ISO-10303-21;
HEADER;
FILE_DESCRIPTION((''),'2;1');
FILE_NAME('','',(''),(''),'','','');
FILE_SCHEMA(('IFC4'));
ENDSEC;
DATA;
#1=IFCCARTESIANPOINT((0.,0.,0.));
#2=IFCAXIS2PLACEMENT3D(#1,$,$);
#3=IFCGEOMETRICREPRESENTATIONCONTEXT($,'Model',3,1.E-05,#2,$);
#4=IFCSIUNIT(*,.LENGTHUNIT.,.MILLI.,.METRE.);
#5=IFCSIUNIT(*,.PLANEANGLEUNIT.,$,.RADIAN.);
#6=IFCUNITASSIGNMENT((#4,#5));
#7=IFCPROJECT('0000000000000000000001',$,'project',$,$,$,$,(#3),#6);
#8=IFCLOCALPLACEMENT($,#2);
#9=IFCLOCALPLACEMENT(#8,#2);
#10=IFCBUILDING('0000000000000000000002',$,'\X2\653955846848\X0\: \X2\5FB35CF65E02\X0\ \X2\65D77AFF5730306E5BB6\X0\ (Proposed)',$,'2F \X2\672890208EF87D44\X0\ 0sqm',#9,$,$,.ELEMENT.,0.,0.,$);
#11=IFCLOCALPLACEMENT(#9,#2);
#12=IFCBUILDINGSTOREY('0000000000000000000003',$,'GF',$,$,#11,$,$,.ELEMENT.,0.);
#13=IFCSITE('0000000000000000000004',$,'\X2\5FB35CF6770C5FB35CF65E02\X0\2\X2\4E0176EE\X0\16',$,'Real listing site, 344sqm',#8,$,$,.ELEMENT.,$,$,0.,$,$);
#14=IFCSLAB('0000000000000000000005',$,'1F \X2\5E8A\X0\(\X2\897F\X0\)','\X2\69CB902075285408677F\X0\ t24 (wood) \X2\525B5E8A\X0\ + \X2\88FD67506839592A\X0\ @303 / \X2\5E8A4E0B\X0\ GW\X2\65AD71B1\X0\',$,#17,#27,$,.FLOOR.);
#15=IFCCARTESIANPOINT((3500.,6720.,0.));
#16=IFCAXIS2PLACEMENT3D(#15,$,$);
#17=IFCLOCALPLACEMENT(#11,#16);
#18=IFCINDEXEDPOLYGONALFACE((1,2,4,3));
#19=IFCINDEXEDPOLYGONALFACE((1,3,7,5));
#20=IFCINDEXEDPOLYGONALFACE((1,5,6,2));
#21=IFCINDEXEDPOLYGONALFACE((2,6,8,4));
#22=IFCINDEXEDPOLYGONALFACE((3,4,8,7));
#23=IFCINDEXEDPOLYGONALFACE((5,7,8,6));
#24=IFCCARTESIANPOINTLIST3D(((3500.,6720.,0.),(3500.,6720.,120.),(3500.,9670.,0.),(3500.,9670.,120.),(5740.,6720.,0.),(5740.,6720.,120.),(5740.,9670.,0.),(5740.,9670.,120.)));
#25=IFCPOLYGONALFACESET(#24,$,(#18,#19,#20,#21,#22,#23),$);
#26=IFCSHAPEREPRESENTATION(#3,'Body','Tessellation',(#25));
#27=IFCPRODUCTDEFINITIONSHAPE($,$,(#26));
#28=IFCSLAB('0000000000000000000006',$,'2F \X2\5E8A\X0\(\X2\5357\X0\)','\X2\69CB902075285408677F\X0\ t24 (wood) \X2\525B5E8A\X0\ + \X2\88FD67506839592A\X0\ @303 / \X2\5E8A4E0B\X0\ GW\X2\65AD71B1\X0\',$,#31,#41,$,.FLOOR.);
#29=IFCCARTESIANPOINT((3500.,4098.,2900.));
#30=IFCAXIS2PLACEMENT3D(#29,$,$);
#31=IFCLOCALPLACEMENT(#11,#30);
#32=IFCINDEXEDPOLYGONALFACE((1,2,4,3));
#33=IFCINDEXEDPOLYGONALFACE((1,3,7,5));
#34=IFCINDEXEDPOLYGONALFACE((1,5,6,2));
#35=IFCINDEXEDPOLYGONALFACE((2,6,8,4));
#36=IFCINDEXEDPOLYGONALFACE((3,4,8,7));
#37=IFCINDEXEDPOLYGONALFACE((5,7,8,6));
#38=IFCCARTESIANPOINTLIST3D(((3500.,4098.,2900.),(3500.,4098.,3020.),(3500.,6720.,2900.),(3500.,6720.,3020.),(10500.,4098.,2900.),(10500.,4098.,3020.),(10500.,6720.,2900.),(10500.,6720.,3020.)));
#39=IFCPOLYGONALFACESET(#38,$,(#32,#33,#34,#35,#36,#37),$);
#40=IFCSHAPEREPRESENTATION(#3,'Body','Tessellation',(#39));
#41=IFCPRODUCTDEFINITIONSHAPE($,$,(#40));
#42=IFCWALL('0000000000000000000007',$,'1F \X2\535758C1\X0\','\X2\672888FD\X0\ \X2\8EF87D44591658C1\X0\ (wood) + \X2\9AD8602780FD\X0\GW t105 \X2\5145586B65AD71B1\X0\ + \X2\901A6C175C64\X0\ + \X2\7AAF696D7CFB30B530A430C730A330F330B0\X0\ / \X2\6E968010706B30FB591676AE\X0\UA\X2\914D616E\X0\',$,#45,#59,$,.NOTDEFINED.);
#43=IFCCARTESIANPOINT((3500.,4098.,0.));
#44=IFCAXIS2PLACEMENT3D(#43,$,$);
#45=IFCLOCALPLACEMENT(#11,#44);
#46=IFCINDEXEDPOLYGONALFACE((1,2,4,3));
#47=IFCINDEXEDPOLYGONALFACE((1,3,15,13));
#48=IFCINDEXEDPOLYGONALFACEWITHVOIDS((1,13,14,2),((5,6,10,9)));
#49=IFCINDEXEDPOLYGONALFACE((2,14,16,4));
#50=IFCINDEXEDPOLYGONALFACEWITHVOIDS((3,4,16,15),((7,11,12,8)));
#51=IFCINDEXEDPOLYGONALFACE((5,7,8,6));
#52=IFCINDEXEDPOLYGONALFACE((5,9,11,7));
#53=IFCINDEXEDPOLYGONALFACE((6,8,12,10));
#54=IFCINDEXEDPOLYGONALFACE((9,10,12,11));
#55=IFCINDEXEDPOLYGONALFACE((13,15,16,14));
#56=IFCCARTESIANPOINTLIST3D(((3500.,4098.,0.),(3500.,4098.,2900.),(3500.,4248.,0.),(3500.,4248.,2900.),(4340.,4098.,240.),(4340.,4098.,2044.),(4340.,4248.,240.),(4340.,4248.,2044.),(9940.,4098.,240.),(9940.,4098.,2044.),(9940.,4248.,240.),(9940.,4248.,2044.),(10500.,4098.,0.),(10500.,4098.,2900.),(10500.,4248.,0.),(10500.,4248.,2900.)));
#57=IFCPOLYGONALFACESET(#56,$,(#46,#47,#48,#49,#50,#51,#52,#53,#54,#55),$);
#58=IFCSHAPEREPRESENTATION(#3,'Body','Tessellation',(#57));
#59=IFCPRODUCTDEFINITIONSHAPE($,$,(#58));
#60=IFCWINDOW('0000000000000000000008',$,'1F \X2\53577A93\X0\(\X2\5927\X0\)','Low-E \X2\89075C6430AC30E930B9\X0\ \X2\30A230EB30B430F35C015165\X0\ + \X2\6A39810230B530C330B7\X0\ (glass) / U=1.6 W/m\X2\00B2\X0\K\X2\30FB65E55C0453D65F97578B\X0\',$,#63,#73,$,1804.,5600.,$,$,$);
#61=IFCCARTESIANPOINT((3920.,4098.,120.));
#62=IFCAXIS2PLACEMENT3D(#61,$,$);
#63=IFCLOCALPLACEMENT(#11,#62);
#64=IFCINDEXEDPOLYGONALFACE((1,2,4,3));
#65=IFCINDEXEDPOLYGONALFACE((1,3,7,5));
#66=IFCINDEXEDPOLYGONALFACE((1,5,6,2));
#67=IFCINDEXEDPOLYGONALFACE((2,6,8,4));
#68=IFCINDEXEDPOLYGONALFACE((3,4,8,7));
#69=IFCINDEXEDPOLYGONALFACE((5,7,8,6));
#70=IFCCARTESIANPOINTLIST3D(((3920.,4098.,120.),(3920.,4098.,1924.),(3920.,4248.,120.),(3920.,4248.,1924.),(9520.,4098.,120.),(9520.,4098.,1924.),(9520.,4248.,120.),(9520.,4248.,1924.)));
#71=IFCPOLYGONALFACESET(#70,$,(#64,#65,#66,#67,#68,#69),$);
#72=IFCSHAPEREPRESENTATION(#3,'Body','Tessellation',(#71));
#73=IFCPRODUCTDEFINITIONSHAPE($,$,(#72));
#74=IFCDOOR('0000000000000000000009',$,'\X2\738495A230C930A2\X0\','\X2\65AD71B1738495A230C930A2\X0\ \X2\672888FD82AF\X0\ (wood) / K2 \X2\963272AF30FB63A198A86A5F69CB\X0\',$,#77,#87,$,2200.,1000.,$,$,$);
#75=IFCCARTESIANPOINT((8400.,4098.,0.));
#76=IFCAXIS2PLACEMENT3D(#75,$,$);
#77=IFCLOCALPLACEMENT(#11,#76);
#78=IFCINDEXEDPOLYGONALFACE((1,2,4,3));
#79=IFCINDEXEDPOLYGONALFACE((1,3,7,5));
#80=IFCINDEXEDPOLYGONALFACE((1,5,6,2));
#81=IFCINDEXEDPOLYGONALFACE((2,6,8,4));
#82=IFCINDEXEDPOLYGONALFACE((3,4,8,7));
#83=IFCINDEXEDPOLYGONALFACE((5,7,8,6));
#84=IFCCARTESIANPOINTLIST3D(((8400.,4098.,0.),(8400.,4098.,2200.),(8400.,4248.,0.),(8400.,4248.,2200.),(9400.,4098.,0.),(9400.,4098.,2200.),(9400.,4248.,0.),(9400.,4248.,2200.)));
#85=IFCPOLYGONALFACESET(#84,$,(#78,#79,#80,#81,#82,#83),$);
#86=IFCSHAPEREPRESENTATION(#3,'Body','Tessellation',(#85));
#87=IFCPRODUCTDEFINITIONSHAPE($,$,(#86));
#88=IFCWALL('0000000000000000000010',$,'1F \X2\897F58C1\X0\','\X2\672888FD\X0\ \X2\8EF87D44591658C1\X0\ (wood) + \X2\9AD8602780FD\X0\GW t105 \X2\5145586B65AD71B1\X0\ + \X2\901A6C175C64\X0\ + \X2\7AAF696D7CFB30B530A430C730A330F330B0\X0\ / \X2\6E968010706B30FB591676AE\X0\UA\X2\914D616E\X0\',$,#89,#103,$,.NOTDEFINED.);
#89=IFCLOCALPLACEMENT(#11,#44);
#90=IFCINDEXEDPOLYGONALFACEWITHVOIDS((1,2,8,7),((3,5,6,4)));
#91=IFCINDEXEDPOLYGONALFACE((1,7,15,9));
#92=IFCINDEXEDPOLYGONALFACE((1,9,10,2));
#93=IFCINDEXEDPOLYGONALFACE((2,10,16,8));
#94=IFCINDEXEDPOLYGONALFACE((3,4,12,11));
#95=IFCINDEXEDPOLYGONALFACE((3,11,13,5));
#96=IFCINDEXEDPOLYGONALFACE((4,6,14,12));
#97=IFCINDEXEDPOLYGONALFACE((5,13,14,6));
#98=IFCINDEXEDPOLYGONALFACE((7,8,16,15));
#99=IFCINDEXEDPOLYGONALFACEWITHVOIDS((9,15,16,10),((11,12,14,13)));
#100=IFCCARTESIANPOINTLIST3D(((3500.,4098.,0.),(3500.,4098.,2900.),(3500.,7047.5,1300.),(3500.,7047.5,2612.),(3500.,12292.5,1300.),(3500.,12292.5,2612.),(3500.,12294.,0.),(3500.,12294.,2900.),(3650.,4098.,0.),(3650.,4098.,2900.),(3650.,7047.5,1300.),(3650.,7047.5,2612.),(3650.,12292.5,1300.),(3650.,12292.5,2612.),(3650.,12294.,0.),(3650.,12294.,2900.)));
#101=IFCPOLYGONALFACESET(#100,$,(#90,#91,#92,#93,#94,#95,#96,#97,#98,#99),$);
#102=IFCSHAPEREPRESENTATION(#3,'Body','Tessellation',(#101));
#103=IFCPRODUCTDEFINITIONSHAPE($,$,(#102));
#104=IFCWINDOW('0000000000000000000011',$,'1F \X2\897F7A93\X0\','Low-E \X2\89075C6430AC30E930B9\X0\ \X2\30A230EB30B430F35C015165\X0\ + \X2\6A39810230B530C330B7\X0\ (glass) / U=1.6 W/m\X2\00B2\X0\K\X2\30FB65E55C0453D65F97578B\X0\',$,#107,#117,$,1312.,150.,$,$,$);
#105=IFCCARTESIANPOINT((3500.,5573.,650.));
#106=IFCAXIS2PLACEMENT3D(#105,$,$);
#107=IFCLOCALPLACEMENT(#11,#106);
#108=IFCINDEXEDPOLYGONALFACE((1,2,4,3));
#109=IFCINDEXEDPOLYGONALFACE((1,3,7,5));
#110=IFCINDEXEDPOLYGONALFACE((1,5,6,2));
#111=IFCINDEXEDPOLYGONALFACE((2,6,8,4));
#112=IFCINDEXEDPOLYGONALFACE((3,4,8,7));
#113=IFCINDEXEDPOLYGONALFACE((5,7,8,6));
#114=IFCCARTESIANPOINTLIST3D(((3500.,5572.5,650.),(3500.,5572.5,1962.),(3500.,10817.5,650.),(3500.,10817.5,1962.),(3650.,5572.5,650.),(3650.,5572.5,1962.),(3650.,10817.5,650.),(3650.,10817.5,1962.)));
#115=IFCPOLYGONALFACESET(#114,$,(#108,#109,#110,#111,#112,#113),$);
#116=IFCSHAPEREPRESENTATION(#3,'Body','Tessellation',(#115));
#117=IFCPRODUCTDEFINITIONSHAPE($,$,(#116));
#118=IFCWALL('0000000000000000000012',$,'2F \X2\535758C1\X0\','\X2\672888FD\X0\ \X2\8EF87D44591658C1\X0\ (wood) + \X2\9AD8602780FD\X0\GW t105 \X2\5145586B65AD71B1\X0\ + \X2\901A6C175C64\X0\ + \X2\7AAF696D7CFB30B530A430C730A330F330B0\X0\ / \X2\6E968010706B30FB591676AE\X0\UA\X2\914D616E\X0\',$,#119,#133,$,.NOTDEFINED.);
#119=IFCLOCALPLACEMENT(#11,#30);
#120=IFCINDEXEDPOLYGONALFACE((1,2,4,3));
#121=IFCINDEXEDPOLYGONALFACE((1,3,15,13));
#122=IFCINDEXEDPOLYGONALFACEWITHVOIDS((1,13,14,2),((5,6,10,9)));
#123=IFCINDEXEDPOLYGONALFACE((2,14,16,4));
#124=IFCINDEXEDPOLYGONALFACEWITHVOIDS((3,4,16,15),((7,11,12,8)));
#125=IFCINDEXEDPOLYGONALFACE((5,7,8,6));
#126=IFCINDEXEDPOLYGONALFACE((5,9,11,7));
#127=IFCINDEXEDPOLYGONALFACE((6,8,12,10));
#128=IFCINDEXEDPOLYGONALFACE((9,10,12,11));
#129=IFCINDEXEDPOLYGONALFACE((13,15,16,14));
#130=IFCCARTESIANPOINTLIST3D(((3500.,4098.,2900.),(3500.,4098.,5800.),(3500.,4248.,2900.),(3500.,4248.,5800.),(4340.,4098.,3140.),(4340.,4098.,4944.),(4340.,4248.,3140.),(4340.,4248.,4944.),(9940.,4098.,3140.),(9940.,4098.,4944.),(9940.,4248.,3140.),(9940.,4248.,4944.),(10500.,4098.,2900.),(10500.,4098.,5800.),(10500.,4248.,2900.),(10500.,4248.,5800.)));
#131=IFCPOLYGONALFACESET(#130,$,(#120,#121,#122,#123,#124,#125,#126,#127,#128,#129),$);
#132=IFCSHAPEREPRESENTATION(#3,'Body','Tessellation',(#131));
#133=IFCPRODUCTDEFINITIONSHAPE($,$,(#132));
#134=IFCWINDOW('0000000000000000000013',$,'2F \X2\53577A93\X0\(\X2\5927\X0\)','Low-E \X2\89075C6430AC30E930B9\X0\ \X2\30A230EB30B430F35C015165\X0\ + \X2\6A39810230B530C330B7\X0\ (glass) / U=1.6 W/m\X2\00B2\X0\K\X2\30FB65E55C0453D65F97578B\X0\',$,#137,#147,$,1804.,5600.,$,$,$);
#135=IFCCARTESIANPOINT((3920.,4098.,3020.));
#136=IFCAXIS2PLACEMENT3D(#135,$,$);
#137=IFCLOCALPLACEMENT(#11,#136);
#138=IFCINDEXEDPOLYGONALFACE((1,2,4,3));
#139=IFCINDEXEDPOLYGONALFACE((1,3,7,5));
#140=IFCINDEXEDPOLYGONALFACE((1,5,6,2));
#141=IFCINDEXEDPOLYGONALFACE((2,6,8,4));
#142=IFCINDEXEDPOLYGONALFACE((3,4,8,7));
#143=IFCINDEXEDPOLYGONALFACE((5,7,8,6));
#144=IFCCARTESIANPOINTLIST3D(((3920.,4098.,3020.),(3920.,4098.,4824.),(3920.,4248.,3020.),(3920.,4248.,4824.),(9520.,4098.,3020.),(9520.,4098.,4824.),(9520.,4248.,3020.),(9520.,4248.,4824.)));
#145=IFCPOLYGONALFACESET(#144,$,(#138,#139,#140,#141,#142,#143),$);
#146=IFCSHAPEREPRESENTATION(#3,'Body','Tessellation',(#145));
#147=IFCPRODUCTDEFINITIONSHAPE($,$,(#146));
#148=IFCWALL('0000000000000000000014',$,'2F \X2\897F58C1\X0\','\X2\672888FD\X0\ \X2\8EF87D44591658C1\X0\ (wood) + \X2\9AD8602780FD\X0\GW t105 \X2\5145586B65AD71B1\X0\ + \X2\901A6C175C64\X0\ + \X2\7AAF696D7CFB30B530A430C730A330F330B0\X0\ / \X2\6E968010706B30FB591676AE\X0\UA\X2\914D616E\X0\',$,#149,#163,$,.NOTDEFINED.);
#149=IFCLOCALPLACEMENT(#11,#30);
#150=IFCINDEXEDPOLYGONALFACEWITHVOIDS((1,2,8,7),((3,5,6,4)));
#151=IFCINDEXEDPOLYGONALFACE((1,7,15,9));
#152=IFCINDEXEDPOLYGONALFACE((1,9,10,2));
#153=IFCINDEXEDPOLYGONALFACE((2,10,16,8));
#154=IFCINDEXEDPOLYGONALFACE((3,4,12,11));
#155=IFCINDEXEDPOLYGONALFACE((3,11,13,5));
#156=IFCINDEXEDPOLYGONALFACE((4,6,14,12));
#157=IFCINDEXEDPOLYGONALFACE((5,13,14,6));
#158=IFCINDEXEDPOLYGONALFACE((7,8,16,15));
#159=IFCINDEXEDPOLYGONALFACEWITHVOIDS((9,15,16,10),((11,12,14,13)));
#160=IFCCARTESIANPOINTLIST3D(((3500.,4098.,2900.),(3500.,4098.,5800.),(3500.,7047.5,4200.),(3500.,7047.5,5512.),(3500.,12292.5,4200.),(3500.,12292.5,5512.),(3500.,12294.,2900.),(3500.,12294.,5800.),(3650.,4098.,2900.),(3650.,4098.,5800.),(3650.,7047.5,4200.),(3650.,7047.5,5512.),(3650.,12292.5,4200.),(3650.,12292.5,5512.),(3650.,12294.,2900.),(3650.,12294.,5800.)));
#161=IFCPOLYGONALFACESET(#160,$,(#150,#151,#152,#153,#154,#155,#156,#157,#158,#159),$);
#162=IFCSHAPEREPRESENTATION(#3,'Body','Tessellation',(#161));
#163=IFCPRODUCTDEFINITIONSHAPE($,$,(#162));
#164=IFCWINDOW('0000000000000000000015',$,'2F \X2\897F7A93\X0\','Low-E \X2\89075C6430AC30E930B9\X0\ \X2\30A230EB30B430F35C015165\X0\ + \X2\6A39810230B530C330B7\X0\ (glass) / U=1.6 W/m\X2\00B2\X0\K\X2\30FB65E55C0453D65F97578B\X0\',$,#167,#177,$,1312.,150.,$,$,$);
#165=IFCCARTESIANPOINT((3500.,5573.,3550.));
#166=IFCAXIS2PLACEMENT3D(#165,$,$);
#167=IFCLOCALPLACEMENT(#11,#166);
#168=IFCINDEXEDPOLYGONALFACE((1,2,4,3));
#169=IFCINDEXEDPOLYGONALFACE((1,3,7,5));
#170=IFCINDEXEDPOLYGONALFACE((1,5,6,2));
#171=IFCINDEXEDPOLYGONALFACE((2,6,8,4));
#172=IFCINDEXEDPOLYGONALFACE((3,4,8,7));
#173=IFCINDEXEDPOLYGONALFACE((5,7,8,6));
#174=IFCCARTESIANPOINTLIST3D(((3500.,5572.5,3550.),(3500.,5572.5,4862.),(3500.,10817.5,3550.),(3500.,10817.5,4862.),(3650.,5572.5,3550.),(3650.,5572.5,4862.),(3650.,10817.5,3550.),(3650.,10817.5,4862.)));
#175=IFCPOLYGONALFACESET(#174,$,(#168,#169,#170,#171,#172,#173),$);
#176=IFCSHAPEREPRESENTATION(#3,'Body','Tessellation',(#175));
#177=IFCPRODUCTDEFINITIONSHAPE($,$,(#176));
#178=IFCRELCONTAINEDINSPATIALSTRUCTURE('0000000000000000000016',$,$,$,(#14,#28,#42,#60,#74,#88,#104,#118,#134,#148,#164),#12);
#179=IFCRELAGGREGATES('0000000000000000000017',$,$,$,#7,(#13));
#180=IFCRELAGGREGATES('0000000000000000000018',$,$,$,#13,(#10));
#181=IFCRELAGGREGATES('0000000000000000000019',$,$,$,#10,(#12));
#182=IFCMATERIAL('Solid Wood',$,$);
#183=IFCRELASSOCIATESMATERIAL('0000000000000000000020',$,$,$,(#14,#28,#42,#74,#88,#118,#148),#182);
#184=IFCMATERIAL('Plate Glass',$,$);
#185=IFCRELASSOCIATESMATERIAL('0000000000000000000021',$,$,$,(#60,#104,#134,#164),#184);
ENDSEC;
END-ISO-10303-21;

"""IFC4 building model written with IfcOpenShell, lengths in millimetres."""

from ifc_helpers import new_model, si_unit, frame, frame_2d, origin, place, context, project, spatial, rectangle, extrude, material, element, fill, save


model = new_model("IFC4")

# Units and contexts
model_context = context("Model", 3, precision=1e-05, world=origin())
ifc_project = project(units=[si_unit("LENGTHUNIT", "METRE", prefix="MILLI"), si_unit("PLANEANGLEUNIT", "RADIAN")], contexts=[model_context])

# Site, building, storey
site_placement = place(None, origin())
site = spatial("IfcSite", under=ifc_project, at=site_placement, Name="徳島県徳島市2丁目16", ObjectType="Real listing site, 344sqm", CompositionType="ELEMENT", RefElevation=0.0)
building_placement = place(site_placement, origin())
building = spatial("IfcBuilding", under=site, at=building_placement, Name="改善案: 徳島市 旗竿地の家 (Proposed)", ObjectType="2F 木造軸組 0sqm", CompositionType="ELEMENT", ElevationOfRefHeight=0.0, ElevationOfTerrain=0.0)
storey_placement = place(building_placement, origin())
storey = spatial("IfcBuildingStorey", under=building, at=storey_placement, Name="GF", CompositionType="ELEMENT", Elevation=0.0)

# Slabs
ifc_material_1 = material(Name="Solid Wood")
slab_1_placement = place(storey_placement, frame((3500.0, 6720.0, 0.0)))
element("IfcSlab", 1, at=slab_1_placement, inside=storey, material=ifc_material_1, Name="1F 床(西)", Description="構造用合板 t24 (wood) 剛床 + 製材根太 @303 / 床下 GW断熱", PredefinedType="FLOOR", context=model_context, shape_type="SweptSolid", body=[
    extrude(rectangle(XDim=2240.0, YDim=2950.0, at=frame_2d((1120.0, 1475.0))), frame((3500.0, 6720.0, 0.0)), (0.0, 0.0, 1.0), 120.0),
])
slab_2_placement = place(storey_placement, frame((3500.0, 4098.0, 2900.0)))
element("IfcSlab", 2, at=slab_2_placement, inside=storey, material=ifc_material_1, Name="2F 床(南)", Description="構造用合板 t24 (wood) 剛床 + 製材根太 @303 / 床下 GW断熱", PredefinedType="FLOOR", context=model_context, shape_type="SweptSolid", body=[
    extrude(rectangle(XDim=7000.0, YDim=2622.0, at=frame_2d((3500.0, 1311.0))), frame((3500.0, 4098.0, 2900.0)), (0.0, 0.0, 1.0), 120.0),
])

# Wall, openings, window, door
wall_1_placement = place(storey_placement, frame((3500.0, 4098.0, 0.0)))
wall_1 = element("IfcWall", 3, at=wall_1_placement, inside=storey, material=ifc_material_1, Name="1F 南壁", Description="木製 軸組外壁 (wood) + 高性能GW t105 充填断熱 + 通気層 + 窯業系サイディング / 準耐火・外皮UA配慮", PredefinedType="NOTDEFINED", context=model_context, shape_type="SweptSolid", body=[
    extrude(rectangle(XDim=7000.0, YDim=150.0, at=frame_2d((3500.0, 75.0))), frame((3500.0, 4098.0, 0.0)), (0.0, 0.0, 1.0), 2900.0),
])
opening_1_placement = place(storey_placement, frame((3920.0, 4098.0, 120.0)))
opening_1 = element("IfcOpeningElement", 4, at=opening_1_placement, cuts=wall_1, PredefinedType="NOTDEFINED", context=model_context, shape_type="SweptSolid", body=[
    extrude(rectangle(XDim=5600.0, YDim=150.0, at=frame_2d((2800.0, 75.0))), frame((3920.0, 4098.0, 120.0)), (0.0, 0.0, 1.0), 1804.0),
])
opening_2_placement = place(storey_placement, frame((8400.0, 4098.0, 0.0)))
opening_2 = element("IfcOpeningElement", 5, at=opening_2_placement, cuts=wall_1, PredefinedType="NOTDEFINED", context=model_context, shape_type="SweptSolid", body=[
    extrude(rectangle(XDim=1000.0, YDim=150.0, at=frame_2d((500.0, 75.0))), frame((8400.0, 4098.0, 0.0)), (0.0, 0.0, 1.0), 2200.0),
])
ifc_material_2 = material(Name="Plate Glass")
window_1_placement = place(storey_placement, frame((3920.0, 4098.0, 120.0)))
window_1 = element("IfcWindow", 6, at=window_1_placement, inside=storey, material=ifc_material_2, Name="1F 南窓(大)", Description="Low-E 複層ガラス アルゴン封入 + 樹脂サッシ (glass) / U=1.6 W/m²K・日射取得型", OverallHeight=1804.0, OverallWidth=5600.0, context=model_context, shape_type="SweptSolid", body=[
    extrude(rectangle(XDim=5600.0, YDim=150.0, at=frame_2d((2800.0, 75.0))), frame((3920.0, 4098.0, 120.0)), (0.0, 0.0, 1.0), 1804.0),
])
fill(opening_1, window_1)
door_placement = place(storey_placement, frame((8400.0, 4098.0, 0.0)))
door = element("IfcDoor", 7, at=door_placement, inside=storey, material=ifc_material_1, Name="玄関ドア", Description="断熱玄関ドア 木製芯 (wood) / K2 防犯・採風機構", OverallHeight=2200.0, OverallWidth=1000.0, context=model_context, shape_type="SweptSolid", body=[
    extrude(rectangle(XDim=1000.0, YDim=150.0, at=frame_2d((500.0, 75.0))), frame((8400.0, 4098.0, 0.0)), (0.0, 0.0, 1.0), 2200.0),
])
fill(opening_2, door)

# Walls, openings, windows
wall_2_placement = place(storey_placement, frame((3500.0, 4098.0, 0.0)))
wall_2 = element("IfcWall", 8, at=wall_2_placement, inside=storey, material=ifc_material_1, Name="1F 西壁", Description="木製 軸組外壁 (wood) + 高性能GW t105 充填断熱 + 通気層 + 窯業系サイディング / 準耐火・外皮UA配慮", PredefinedType="NOTDEFINED", context=model_context, shape_type="SweptSolid", body=[
    extrude(rectangle(XDim=150.0, YDim=8196.0, at=frame_2d((75.0, 4098.0))), frame((3500.0, 4098.0, 0.0)), (0.0, 0.0, 1.0), 2900.0),
])
opening_3_placement = place(storey_placement, frame((3500.0, 5573.0, 650.0)))
opening_3 = element("IfcOpeningElement", 9, at=opening_3_placement, cuts=wall_2, PredefinedType="NOTDEFINED", context=model_context, shape_type="SweptSolid", body=[
    extrude(rectangle(XDim=150.0, YDim=5245.0, at=frame_2d((75.0, 2622.0))), frame((3500.0, 5573.0, 650.0)), (0.0, 0.0, 1.0), 1312.0),
])
window_2_placement = place(storey_placement, frame((3500.0, 5573.0, 650.0)))
window_2 = element("IfcWindow", 10, at=window_2_placement, inside=storey, material=ifc_material_2, Name="1F 西窓", Description="Low-E 複層ガラス アルゴン封入 + 樹脂サッシ (glass) / U=1.6 W/m²K・日射取得型", OverallHeight=1312.0, OverallWidth=150.0, context=model_context, shape_type="SweptSolid", body=[
    extrude(rectangle(XDim=150.0, YDim=5245.0, at=frame_2d((75.0, 2622.0))), frame((3500.0, 5573.0, 650.0)), (0.0, 0.0, 1.0), 1312.0),
])
fill(opening_3, window_2)
wall_3_placement = place(storey_placement, frame((3500.0, 4098.0, 2900.0)))
wall_3 = element("IfcWall", 11, at=wall_3_placement, inside=storey, material=ifc_material_1, Name="2F 南壁", Description="木製 軸組外壁 (wood) + 高性能GW t105 充填断熱 + 通気層 + 窯業系サイディング / 準耐火・外皮UA配慮", PredefinedType="NOTDEFINED", context=model_context, shape_type="SweptSolid", body=[
    extrude(rectangle(XDim=7000.0, YDim=150.0, at=frame_2d((3500.0, 75.0))), frame((3500.0, 4098.0, 2900.0)), (0.0, 0.0, 1.0), 2900.0),
])
opening_4_placement = place(storey_placement, frame((3920.0, 4098.0, 3020.0)))
opening_4 = element("IfcOpeningElement", 12, at=opening_4_placement, cuts=wall_3, PredefinedType="NOTDEFINED", context=model_context, shape_type="SweptSolid", body=[
    extrude(rectangle(XDim=5600.0, YDim=150.0, at=frame_2d((2800.0, 75.0))), frame((3920.0, 4098.0, 3020.0)), (0.0, 0.0, 1.0), 1804.0),
])
window_3_placement = place(storey_placement, frame((3920.0, 4098.0, 3020.0)))
window_3 = element("IfcWindow", 13, at=window_3_placement, inside=storey, material=ifc_material_2, Name="2F 南窓(大)", Description="Low-E 複層ガラス アルゴン封入 + 樹脂サッシ (glass) / U=1.6 W/m²K・日射取得型", OverallHeight=1804.0, OverallWidth=5600.0, context=model_context, shape_type="SweptSolid", body=[
    extrude(rectangle(XDim=5600.0, YDim=150.0, at=frame_2d((2800.0, 75.0))), frame((3920.0, 4098.0, 3020.0)), (0.0, 0.0, 1.0), 1804.0),
])
fill(opening_4, window_3)
wall_4_placement = place(storey_placement, frame((3500.0, 4098.0, 2900.0)))
wall_4 = element("IfcWall", 14, at=wall_4_placement, inside=storey, material=ifc_material_1, Name="2F 西壁", Description="木製 軸組外壁 (wood) + 高性能GW t105 充填断熱 + 通気層 + 窯業系サイディング / 準耐火・外皮UA配慮", PredefinedType="NOTDEFINED", context=model_context, shape_type="SweptSolid", body=[
    extrude(rectangle(XDim=150.0, YDim=8196.0, at=frame_2d((75.0, 4098.0))), frame((3500.0, 4098.0, 2900.0)), (0.0, 0.0, 1.0), 2900.0),
])
opening_5_placement = place(storey_placement, frame((3500.0, 5573.0, 3550.0)))
opening_5 = element("IfcOpeningElement", 15, at=opening_5_placement, cuts=wall_4, PredefinedType="NOTDEFINED", context=model_context, shape_type="SweptSolid", body=[
    extrude(rectangle(XDim=150.0, YDim=5245.0, at=frame_2d((75.0, 2622.0))), frame((3500.0, 5573.0, 3550.0)), (0.0, 0.0, 1.0), 1312.0),
])
window_4_placement = place(storey_placement, frame((3500.0, 5573.0, 3550.0)))
window_4 = element("IfcWindow", 16, at=window_4_placement, inside=storey, material=ifc_material_2, Name="2F 西窓", Description="Low-E 複層ガラス アルゴン封入 + 樹脂サッシ (glass) / U=1.6 W/m²K・日射取得型", OverallHeight=1312.0, OverallWidth=150.0, context=model_context, shape_type="SweptSolid", body=[
    extrude(rectangle(XDim=150.0, YDim=5245.0, at=frame_2d((75.0, 2622.0))), frame((3500.0, 5573.0, 3550.0)), (0.0, 0.0, 1.0), 1312.0),
])
fill(opening_5, window_4)

save(model, "model.ifc")
